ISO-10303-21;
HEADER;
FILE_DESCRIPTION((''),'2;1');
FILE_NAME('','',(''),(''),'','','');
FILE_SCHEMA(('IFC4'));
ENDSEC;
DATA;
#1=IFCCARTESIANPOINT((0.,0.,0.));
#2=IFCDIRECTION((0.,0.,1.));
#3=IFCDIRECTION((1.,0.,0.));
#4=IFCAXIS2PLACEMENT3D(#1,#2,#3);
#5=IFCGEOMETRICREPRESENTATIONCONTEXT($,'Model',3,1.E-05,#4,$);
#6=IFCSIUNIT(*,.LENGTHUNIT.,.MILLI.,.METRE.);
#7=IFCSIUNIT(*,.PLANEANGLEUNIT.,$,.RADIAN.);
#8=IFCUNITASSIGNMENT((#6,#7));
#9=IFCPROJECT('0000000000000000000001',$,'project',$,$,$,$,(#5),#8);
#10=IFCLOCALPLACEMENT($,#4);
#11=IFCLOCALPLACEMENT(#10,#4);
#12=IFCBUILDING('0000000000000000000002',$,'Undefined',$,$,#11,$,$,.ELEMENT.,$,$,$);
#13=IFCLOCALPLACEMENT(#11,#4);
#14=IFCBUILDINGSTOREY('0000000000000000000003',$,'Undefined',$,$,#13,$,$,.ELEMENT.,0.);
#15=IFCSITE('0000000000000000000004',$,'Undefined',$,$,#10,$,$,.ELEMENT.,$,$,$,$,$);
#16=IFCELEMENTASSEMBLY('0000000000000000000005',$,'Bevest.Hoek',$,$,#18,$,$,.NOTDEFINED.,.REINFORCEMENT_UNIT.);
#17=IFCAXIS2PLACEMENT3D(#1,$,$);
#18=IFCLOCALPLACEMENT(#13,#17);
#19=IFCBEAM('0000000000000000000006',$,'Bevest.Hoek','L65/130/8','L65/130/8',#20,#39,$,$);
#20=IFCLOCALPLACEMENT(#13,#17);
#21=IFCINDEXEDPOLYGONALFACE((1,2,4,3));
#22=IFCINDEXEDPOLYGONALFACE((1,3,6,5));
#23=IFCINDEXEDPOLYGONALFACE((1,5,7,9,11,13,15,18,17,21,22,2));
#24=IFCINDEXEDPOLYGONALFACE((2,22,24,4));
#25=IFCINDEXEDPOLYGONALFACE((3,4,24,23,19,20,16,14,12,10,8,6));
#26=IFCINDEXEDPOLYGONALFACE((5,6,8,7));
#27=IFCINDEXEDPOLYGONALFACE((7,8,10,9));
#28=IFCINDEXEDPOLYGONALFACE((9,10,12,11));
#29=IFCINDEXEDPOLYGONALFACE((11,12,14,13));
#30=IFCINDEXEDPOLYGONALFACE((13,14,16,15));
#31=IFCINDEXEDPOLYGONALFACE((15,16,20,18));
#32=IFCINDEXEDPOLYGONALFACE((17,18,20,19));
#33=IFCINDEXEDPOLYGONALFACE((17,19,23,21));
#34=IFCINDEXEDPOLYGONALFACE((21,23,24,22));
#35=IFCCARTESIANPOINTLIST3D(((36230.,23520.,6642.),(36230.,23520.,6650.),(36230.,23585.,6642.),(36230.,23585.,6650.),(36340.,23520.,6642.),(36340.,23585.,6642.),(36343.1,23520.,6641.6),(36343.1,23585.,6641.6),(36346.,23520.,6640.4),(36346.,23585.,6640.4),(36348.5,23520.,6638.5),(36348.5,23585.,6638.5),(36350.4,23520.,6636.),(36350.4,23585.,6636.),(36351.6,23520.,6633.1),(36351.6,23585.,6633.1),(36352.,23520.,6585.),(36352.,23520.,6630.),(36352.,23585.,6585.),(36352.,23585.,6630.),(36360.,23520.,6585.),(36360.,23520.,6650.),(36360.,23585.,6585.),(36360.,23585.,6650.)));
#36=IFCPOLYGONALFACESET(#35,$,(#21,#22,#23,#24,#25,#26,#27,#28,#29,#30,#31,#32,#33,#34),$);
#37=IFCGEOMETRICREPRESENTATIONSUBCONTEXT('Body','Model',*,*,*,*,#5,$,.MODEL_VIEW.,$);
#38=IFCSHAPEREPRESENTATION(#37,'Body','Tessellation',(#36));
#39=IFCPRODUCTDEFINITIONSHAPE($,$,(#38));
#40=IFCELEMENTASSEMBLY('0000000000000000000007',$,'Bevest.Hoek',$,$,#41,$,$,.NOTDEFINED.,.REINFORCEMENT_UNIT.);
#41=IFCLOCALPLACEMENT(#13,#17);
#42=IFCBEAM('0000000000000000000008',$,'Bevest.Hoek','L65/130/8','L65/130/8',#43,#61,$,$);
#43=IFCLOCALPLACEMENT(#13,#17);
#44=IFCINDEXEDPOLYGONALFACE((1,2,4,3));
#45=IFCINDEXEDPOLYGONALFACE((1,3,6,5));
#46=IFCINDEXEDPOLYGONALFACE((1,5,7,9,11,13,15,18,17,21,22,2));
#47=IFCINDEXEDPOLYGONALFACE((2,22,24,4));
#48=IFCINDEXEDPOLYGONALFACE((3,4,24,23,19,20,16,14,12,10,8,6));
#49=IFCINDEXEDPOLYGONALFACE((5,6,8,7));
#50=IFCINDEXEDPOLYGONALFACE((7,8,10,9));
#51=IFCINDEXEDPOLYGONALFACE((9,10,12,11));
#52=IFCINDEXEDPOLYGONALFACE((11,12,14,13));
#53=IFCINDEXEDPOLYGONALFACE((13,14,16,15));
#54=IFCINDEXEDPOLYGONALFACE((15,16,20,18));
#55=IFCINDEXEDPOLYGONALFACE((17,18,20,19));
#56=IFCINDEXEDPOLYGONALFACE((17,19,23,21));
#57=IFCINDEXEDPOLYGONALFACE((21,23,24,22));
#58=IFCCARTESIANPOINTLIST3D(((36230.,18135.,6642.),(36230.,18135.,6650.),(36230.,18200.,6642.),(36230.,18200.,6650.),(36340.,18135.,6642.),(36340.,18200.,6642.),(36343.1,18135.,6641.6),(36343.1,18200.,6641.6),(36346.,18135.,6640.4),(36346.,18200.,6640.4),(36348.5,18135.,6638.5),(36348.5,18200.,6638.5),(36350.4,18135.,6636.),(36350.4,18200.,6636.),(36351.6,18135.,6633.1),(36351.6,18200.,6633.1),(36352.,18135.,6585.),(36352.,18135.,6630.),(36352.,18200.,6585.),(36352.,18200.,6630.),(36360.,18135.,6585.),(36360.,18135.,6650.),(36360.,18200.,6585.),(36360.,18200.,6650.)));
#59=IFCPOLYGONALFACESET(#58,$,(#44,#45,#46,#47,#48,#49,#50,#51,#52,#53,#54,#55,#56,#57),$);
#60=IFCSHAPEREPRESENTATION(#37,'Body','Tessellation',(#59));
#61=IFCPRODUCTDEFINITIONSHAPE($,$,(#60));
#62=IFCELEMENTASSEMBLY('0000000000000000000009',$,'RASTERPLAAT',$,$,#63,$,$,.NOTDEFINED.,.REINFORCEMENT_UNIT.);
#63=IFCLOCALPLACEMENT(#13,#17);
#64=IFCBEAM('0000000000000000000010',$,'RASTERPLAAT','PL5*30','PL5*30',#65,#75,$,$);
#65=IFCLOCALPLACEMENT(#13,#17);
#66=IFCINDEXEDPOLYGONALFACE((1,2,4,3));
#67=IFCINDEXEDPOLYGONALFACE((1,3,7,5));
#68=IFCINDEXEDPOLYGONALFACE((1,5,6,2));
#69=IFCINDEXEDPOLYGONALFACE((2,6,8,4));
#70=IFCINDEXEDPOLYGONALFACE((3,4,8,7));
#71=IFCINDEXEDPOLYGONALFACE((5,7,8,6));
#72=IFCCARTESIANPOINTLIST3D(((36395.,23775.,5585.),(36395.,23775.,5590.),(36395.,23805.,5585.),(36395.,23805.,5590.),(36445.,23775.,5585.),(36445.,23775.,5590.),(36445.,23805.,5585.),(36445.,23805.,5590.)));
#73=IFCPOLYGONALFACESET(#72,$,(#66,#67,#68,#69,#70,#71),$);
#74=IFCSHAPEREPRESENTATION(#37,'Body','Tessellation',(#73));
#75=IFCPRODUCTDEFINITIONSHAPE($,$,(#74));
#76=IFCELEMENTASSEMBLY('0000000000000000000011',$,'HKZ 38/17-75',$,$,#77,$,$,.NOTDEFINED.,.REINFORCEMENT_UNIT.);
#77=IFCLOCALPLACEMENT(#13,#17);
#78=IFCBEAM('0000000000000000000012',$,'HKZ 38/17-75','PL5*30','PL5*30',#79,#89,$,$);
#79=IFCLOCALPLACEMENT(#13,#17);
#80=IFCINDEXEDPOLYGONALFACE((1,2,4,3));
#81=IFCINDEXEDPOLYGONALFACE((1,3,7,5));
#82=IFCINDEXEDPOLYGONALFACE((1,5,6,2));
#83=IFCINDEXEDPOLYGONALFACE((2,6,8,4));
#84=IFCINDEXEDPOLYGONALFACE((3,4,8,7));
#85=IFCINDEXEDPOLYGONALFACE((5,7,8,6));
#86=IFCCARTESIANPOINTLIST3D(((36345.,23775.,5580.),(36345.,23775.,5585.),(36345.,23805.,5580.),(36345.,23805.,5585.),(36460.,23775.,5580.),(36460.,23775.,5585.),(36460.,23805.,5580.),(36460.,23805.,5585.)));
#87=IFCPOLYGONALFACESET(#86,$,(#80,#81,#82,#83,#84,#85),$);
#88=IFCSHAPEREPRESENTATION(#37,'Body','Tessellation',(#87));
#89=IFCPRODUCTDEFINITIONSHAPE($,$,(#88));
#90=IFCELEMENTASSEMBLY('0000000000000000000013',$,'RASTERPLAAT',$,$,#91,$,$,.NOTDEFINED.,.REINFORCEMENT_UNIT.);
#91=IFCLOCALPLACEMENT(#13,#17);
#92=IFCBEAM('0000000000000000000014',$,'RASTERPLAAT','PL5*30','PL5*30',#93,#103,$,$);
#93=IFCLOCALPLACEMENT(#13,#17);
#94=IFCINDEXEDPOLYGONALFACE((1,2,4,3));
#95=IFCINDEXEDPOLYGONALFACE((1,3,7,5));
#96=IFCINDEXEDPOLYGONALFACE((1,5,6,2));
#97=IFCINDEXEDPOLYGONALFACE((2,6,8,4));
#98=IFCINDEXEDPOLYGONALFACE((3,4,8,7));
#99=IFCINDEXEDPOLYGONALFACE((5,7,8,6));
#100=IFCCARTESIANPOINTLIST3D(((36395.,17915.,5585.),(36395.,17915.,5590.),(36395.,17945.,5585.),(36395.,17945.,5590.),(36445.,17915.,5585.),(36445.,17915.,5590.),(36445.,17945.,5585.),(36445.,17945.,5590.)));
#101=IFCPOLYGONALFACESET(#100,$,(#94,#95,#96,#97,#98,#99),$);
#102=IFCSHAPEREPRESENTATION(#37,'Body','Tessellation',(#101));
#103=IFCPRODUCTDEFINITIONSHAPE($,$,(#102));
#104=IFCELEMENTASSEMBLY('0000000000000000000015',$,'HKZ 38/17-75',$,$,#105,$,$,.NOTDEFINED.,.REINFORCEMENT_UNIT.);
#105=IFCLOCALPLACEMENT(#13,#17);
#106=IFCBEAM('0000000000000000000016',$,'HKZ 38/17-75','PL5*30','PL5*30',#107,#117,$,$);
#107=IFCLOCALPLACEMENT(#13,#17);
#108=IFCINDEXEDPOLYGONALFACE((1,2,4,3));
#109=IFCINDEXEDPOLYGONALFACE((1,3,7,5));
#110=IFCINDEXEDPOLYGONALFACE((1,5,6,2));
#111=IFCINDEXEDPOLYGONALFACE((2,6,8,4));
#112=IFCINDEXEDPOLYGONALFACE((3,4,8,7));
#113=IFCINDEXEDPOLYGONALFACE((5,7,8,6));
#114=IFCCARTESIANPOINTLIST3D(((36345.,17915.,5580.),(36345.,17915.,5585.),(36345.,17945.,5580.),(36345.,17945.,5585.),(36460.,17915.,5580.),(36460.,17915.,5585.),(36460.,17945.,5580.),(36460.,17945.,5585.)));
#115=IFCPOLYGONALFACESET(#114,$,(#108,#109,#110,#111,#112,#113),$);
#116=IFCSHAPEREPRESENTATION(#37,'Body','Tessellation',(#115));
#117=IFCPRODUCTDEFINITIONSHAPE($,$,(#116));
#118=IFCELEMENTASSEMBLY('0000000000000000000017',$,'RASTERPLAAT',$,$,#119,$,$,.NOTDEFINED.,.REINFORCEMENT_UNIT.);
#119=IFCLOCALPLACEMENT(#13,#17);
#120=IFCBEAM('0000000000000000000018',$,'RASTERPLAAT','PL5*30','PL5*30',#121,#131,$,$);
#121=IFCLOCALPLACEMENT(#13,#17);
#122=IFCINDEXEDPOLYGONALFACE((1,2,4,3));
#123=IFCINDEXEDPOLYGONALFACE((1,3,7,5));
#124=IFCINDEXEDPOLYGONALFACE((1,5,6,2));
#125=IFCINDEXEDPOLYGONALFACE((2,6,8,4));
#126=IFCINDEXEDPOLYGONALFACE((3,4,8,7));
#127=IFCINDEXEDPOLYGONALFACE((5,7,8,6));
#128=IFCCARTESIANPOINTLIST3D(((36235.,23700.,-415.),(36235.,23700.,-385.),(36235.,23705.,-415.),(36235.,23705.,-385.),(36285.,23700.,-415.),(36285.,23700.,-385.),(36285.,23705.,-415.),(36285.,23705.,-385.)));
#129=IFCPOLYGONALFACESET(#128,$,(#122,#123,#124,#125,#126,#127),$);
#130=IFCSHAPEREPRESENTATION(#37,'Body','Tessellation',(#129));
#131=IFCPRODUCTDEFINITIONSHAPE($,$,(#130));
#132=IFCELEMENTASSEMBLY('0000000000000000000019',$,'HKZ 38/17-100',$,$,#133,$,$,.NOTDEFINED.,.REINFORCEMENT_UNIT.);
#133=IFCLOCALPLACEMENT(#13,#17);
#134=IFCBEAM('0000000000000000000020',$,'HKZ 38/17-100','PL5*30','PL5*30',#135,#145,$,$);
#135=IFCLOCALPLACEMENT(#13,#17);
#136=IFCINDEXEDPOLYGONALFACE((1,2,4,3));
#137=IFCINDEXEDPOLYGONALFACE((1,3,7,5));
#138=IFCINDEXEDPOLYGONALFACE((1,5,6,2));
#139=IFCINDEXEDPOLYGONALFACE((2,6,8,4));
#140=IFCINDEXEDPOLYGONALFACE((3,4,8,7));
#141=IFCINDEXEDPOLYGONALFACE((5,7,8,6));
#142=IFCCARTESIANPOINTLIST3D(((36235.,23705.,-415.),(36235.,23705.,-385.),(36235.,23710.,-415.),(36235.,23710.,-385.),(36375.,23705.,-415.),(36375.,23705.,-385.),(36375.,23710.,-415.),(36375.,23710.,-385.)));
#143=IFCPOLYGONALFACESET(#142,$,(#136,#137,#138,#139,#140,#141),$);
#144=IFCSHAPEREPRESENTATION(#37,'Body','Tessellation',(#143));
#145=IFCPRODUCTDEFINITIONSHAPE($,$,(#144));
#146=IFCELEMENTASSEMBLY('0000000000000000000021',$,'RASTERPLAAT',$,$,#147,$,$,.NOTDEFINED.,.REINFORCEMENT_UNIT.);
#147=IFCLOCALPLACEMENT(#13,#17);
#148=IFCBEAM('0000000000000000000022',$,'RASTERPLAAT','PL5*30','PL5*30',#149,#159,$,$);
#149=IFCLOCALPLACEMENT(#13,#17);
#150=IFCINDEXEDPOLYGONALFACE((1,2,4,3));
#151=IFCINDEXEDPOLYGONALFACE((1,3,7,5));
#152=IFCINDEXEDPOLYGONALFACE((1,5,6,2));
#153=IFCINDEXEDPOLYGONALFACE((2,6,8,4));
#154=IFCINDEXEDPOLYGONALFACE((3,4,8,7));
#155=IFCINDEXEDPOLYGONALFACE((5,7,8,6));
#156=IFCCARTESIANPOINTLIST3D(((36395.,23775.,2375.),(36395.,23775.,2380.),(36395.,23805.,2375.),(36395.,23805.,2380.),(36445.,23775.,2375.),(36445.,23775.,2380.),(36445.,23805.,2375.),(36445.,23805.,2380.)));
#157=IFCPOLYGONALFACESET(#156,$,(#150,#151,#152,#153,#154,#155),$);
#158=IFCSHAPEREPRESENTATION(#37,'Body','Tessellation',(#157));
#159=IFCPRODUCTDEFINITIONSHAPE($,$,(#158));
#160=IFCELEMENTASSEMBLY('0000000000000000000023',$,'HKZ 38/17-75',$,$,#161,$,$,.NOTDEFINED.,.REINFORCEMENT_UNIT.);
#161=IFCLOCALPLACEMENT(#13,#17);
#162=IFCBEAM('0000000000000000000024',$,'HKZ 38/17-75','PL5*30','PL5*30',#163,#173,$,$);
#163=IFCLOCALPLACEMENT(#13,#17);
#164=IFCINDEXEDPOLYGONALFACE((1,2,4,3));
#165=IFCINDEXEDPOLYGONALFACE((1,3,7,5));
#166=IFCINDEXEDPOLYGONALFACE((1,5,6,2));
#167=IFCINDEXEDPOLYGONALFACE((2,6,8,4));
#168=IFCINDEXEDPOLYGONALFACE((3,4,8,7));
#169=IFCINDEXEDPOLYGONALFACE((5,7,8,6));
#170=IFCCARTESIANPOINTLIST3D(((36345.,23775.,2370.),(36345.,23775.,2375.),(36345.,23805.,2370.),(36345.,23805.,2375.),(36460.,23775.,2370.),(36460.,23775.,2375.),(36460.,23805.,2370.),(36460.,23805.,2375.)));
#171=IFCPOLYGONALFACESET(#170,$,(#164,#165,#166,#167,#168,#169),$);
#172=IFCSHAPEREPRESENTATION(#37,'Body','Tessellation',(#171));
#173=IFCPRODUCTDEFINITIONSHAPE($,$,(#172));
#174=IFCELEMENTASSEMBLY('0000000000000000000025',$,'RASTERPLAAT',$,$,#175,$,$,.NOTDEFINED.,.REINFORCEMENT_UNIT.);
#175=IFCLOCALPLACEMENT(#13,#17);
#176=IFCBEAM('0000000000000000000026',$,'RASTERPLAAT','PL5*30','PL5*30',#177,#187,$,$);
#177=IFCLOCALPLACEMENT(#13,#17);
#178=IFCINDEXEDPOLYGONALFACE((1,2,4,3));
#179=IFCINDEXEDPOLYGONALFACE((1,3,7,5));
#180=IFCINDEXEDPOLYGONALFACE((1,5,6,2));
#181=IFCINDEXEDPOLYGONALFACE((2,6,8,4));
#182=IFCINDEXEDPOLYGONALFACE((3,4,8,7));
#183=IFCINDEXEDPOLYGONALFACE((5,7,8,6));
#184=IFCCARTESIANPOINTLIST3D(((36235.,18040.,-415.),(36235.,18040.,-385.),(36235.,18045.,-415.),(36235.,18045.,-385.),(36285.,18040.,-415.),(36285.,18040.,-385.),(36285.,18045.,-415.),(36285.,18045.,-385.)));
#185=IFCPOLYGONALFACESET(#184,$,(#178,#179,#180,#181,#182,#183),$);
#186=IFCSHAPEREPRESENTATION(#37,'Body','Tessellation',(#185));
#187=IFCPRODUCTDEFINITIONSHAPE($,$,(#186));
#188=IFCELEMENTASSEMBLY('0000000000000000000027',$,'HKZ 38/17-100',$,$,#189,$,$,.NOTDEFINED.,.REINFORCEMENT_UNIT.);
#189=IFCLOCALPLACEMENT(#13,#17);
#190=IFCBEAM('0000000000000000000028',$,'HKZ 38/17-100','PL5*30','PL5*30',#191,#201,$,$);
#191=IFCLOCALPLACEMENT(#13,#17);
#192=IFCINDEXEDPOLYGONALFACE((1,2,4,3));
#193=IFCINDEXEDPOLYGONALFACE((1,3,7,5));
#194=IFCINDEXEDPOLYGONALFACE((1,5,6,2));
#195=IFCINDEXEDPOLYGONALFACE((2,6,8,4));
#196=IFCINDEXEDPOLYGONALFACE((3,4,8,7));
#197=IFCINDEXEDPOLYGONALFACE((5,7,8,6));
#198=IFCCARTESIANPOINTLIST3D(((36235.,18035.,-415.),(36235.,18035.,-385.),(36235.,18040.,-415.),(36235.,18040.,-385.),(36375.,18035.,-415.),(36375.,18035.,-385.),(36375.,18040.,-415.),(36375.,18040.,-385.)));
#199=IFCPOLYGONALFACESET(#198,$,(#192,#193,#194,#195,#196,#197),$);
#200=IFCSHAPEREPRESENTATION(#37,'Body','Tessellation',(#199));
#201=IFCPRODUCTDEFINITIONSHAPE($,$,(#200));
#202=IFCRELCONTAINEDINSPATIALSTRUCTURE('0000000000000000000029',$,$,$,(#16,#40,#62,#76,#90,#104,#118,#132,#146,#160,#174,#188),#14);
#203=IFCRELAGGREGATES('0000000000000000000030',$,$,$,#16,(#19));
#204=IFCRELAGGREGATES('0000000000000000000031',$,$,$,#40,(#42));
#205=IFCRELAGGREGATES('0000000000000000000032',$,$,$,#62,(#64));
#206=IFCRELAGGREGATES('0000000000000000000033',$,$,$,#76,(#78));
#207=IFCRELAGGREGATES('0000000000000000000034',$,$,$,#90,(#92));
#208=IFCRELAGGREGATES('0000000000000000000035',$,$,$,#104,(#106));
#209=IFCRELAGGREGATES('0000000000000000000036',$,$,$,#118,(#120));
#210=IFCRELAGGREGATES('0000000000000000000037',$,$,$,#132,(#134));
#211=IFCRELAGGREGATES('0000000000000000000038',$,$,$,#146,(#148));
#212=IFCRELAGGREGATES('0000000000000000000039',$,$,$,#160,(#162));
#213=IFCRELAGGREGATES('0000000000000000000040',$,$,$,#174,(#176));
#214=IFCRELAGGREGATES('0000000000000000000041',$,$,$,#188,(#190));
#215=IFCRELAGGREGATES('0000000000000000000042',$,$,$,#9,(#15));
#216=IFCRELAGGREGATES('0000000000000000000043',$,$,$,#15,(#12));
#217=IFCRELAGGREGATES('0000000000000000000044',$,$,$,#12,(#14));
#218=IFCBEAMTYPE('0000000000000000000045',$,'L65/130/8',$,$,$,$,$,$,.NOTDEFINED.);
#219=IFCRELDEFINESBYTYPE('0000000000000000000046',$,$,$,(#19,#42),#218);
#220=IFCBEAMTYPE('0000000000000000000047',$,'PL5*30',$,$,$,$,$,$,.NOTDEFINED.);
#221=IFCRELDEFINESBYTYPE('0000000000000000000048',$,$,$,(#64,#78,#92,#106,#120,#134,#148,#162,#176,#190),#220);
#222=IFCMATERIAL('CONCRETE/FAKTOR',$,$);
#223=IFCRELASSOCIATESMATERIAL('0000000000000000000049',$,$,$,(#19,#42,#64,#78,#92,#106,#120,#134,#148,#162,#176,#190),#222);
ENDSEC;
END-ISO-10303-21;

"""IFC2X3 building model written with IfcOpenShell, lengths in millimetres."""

from ifc_helpers import new_model, si_unit, frame, frame_2d, origin_with_axes, place, context, subcontext, project, spatial, rectangle, l_section, extrude, material, type_object, element, aggregate, save


model = new_model("IFC2X3")

# Units and contexts
model_context = context("Model", 3, precision=1e-05, world=origin_with_axes())
body_context = subcontext(model_context, "Body", "Model", "MODEL_VIEW")
ifc_project = project(units=[si_unit("LENGTHUNIT", "METRE", prefix="MILLI"), si_unit("PLANEANGLEUNIT", "RADIAN")], contexts=[model_context])

# Site, building, storey
site_placement = place(None, origin_with_axes())
site = spatial("IfcSite", under=ifc_project, at=site_placement, Name="Undefined", CompositionType="ELEMENT")
building_placement = place(site_placement, origin_with_axes())
building = spatial("IfcBuilding", under=site, at=building_placement, Name="Undefined", CompositionType="ELEMENT")
storey_placement = place(building_placement, origin_with_axes())
storey = spatial("IfcBuildingStorey", under=building, at=storey_placement, Name="Undefined", CompositionType="ELEMENT", Elevation=0.0)

# Element assemblies, beams
assembly_1_placement = place(storey_placement, origin_with_axes())
assembly_1 = element("IfcElementAssembly", 1, at=assembly_1_placement, inside=storey, Name="Bevest.Hoek", AssemblyPlace="NOTDEFINED", PredefinedType="REINFORCEMENT_UNIT")
ifc_material_1 = material(Name="CONCRETE/FAKTOR")
beam_type_1 = type_object("IfcBeamType", Name="L65/130/8", PredefinedType="NOTDEFINED")
beam_1_placement = place(assembly_1_placement, frame((36295.0, 23520.0, 6617.5), z_axis=(0.0, 0.0, -1.0), x_axis=(0.0, 1.0, 0.0)))
beam_1 = element("IfcBeam", 2, at=beam_1_placement, type_object=beam_type_1, material=ifc_material_1, Name="Bevest.Hoek", Description="L65/130/8", ObjectType="L65/130/8", context=body_context, shape_type="SweptSolid", body=[
    extrude(l_section(Depth=65.0, Width=130.0, Thickness=8.0, FilletRadius=12.0, at=frame_2d((0.0, 0.0), x_axis=(1.0, 0.0))), frame((65.0, 0.0, 0.0), z_axis=(-1.0, 0.0, 0.0), x_axis=(0.0, -1.0, 0.0)), (0.0, 0.0, 1.0), 65.0),
])
aggregate(assembly_1, [beam_1])
assembly_2_placement = place(storey_placement, origin_with_axes())
assembly_2 = element("IfcElementAssembly", 3, at=assembly_2_placement, inside=storey, Name="Bevest.Hoek", AssemblyPlace="NOTDEFINED", PredefinedType="REINFORCEMENT_UNIT")
beam_2_placement = place(assembly_2_placement, frame((36295.0, 18135.0, 6617.5), z_axis=(0.0, 0.0, -1.0), x_axis=(0.0, 1.0, 0.0)))
beam_2 = element("IfcBeam", 4, at=beam_2_placement, type_object=beam_type_1, material=ifc_material_1, Name="Bevest.Hoek", Description="L65/130/8", ObjectType="L65/130/8", context=body_context, shape_type="SweptSolid", body=[
    extrude(l_section(Depth=65.0, Width=130.0, Thickness=8.0, FilletRadius=12.0, at=frame_2d((0.0, 0.0), x_axis=(1.0, 0.0))), frame((65.0, 0.0, 0.0), z_axis=(-1.0, 0.0, 0.0), x_axis=(0.0, -1.0, 0.0)), (0.0, 0.0, 1.0), 65.0),
])
aggregate(assembly_2, [beam_2])
assembly_3_placement = place(storey_placement, origin_with_axes())
assembly_3 = element("IfcElementAssembly", 5, at=assembly_3_placement, inside=storey, Name="RASTERPLAAT", AssemblyPlace="NOTDEFINED", PredefinedType="REINFORCEMENT_UNIT")
beam_type_2 = type_object("IfcBeamType", Name="PL5*30", PredefinedType="NOTDEFINED")
beam_3_placement = place(assembly_3_placement, frame((36395.0, 23790.0, 5587.5), z_axis=(0.0, 1.0, 0.0), x_axis=(1.0, 0.0, 0.0)))
beam_3 = element("IfcBeam", 6, at=beam_3_placement, type_object=beam_type_2, material=ifc_material_1, Name="RASTERPLAAT", Description="PL5*30", ObjectType="PL5*30", context=body_context, shape_type="SweptSolid", body=[
    extrude(rectangle(XDim=5.0, YDim=30.0, at=frame_2d((0.0, 0.0), x_axis=(1.0, 0.0))), frame((50.0, 0.0, 0.0), z_axis=(-1.0, 0.0, 0.0), x_axis=(0.0, -1.0, 0.0)), (0.0, 0.0, 1.0), 50.0),
])
aggregate(assembly_3, [beam_3])
assembly_4_placement = place(storey_placement, origin_with_axes())
assembly_4 = element("IfcElementAssembly", 7, at=assembly_4_placement, inside=storey, Name="HKZ 38/17-75", AssemblyPlace="NOTDEFINED", PredefinedType="REINFORCEMENT_UNIT")
beam_4_placement = place(assembly_4_placement, frame((36345.0, 23790.0, 5582.5), z_axis=(0.0, 1.0, 0.0), x_axis=(1.0, 0.0, 0.0)))
beam_4 = element("IfcBeam", 8, at=beam_4_placement, type_object=beam_type_2, material=ifc_material_1, Name="HKZ 38/17-75", Description="PL5*30", ObjectType="PL5*30", context=body_context, shape_type="SweptSolid", body=[
    extrude(rectangle(XDim=5.0, YDim=30.0, at=frame_2d((0.0, 0.0), x_axis=(1.0, 0.0))), frame((115.0, 0.0, 0.0), z_axis=(-1.0, 0.0, 0.0), x_axis=(0.0, -1.0, 0.0)), (0.0, 0.0, 1.0), 115.0),
])
aggregate(assembly_4, [beam_4])
assembly_5_placement = place(storey_placement, origin_with_axes())
assembly_5 = element("IfcElementAssembly", 9, at=assembly_5_placement, inside=storey, Name="RASTERPLAAT", AssemblyPlace="NOTDEFINED", PredefinedType="REINFORCEMENT_UNIT")
beam_5_placement = place(assembly_5_placement, frame((36395.0, 17930.0, 5587.5), z_axis=(0.0, -1.0, 0.0), x_axis=(1.0, 0.0, 0.0)))
beam_5 = element("IfcBeam", 10, at=beam_5_placement, type_object=beam_type_2, material=ifc_material_1, Name="RASTERPLAAT", Description="PL5*30", ObjectType="PL5*30", context=body_context, shape_type="SweptSolid", body=[
    extrude(rectangle(XDim=5.0, YDim=30.0, at=frame_2d((0.0, 0.0), x_axis=(1.0, 0.0))), frame((50.0, 0.0, 0.0), z_axis=(-1.0, 0.0, 0.0), x_axis=(0.0, -1.0, 0.0)), (0.0, 0.0, 1.0), 50.0),
])
aggregate(assembly_5, [beam_5])
assembly_6_placement = place(storey_placement, origin_with_axes())
assembly_6 = element("IfcElementAssembly", 11, at=assembly_6_placement, inside=storey, Name="HKZ 38/17-75", AssemblyPlace="NOTDEFINED", PredefinedType="REINFORCEMENT_UNIT")
beam_6_placement = place(assembly_6_placement, frame((36345.0, 17930.0, 5582.5), z_axis=(0.0, -1.0, 0.0), x_axis=(1.0, 0.0, 0.0)))
beam_6 = element("IfcBeam", 12, at=beam_6_placement, type_object=beam_type_2, material=ifc_material_1, Name="HKZ 38/17-75", Description="PL5*30", ObjectType="PL5*30", context=body_context, shape_type="SweptSolid", body=[
    extrude(rectangle(XDim=5.0, YDim=30.0, at=frame_2d((0.0, 0.0), x_axis=(1.0, 0.0))), frame((115.0, 0.0, 0.0), z_axis=(-1.0, 0.0, 0.0), x_axis=(0.0, -1.0, 0.0)), (0.0, 0.0, 1.0), 115.0),
])
aggregate(assembly_6, [beam_6])
assembly_7_placement = place(storey_placement, origin_with_axes())
assembly_7 = element("IfcElementAssembly", 13, at=assembly_7_placement, inside=storey, Name="RASTERPLAAT", AssemblyPlace="NOTDEFINED", PredefinedType="REINFORCEMENT_UNIT")
beam_7_placement = place(assembly_7_placement, frame((36235.0, 23702.5, -400.0), z_axis=(0.0, 0.0, -1.0), x_axis=(1.0, 0.0, 0.0)))
beam_7 = element("IfcBeam", 14, at=beam_7_placement, type_object=beam_type_2, material=ifc_material_1, Name="RASTERPLAAT", Description="PL5*30", ObjectType="PL5*30", context=body_context, shape_type="SweptSolid", body=[
    extrude(rectangle(XDim=5.0, YDim=30.0, at=frame_2d((0.0, 0.0), x_axis=(1.0, 0.0))), frame((50.0, 0.0, 0.0), z_axis=(-1.0, 0.0, 0.0), x_axis=(0.0, -1.0, 0.0)), (0.0, 0.0, 1.0), 50.0),
])
aggregate(assembly_7, [beam_7])
assembly_8_placement = place(storey_placement, origin_with_axes())
assembly_8 = element("IfcElementAssembly", 15, at=assembly_8_placement, inside=storey, Name="HKZ 38/17-100", AssemblyPlace="NOTDEFINED", PredefinedType="REINFORCEMENT_UNIT")
beam_8_placement = place(assembly_8_placement, frame((36375.0, 23707.5, -400.0), z_axis=(0.0, 0.0, -1.0), x_axis=(-1.0, 0.0, 0.0)))
beam_8 = element("IfcBeam", 16, at=beam_8_placement, type_object=beam_type_2, material=ifc_material_1, Name="HKZ 38/17-100", Description="PL5*30", ObjectType="PL5*30", context=body_context, shape_type="SweptSolid", body=[
    extrude(rectangle(XDim=5.0, YDim=30.0, at=frame_2d((0.0, 0.0), x_axis=(1.0, 0.0))), frame((140.0, 0.0, 0.0), z_axis=(-1.0, 0.0, 0.0), x_axis=(0.0, -1.0, 0.0)), (0.0, 0.0, 1.0), 140.0),
])
aggregate(assembly_8, [beam_8])
assembly_9_placement = place(storey_placement, origin_with_axes())
assembly_9 = element("IfcElementAssembly", 17, at=assembly_9_placement, inside=storey, Name="RASTERPLAAT", AssemblyPlace="NOTDEFINED", PredefinedType="REINFORCEMENT_UNIT")
beam_9_placement = place(assembly_9_placement, frame((36395.0, 23790.0, 2377.5), z_axis=(0.0, 1.0, 0.0), x_axis=(1.0, 0.0, 0.0)))
beam_9 = element("IfcBeam", 18, at=beam_9_placement, type_object=beam_type_2, material=ifc_material_1, Name="RASTERPLAAT", Description="PL5*30", ObjectType="PL5*30", context=body_context, shape_type="SweptSolid", body=[
    extrude(rectangle(XDim=5.0, YDim=30.0, at=frame_2d((0.0, 0.0), x_axis=(1.0, 0.0))), frame((50.0, 0.0, 0.0), z_axis=(-1.0, 0.0, 0.0), x_axis=(0.0, -1.0, 0.0)), (0.0, 0.0, 1.0), 50.0),
])
aggregate(assembly_9, [beam_9])
assembly_10_placement = place(storey_placement, origin_with_axes())
assembly_10 = element("IfcElementAssembly", 19, at=assembly_10_placement, inside=storey, Name="HKZ 38/17-75", AssemblyPlace="NOTDEFINED", PredefinedType="REINFORCEMENT_UNIT")
beam_10_placement = place(assembly_10_placement, frame((36345.0, 23790.0, 2372.5), z_axis=(0.0, 1.0, 0.0), x_axis=(1.0, 0.0, 0.0)))
beam_10 = element("IfcBeam", 20, at=beam_10_placement, type_object=beam_type_2, material=ifc_material_1, Name="HKZ 38/17-75", Description="PL5*30", ObjectType="PL5*30", context=body_context, shape_type="SweptSolid", body=[
    extrude(rectangle(XDim=5.0, YDim=30.0, at=frame_2d((0.0, 0.0), x_axis=(1.0, 0.0))), frame((115.0, 0.0, 0.0), z_axis=(-1.0, 0.0, 0.0), x_axis=(0.0, -1.0, 0.0)), (0.0, 0.0, 1.0), 115.0),
])
aggregate(assembly_10, [beam_10])
assembly_11_placement = place(storey_placement, origin_with_axes())
assembly_11 = element("IfcElementAssembly", 21, at=assembly_11_placement, inside=storey, Name="RASTERPLAAT", AssemblyPlace="NOTDEFINED", PredefinedType="REINFORCEMENT_UNIT")
beam_11_placement = place(assembly_11_placement, frame((36235.0, 18042.5, -400.0), z_axis=(0.0, 0.0, 1.0), x_axis=(1.0, 0.0, 0.0)))
beam_11 = element("IfcBeam", 22, at=beam_11_placement, type_object=beam_type_2, material=ifc_material_1, Name="RASTERPLAAT", Description="PL5*30", ObjectType="PL5*30", context=body_context, shape_type="SweptSolid", body=[
    extrude(rectangle(XDim=5.0, YDim=30.0, at=frame_2d((0.0, 0.0), x_axis=(1.0, 0.0))), frame((50.0, 0.0, 0.0), z_axis=(-1.0, 0.0, 0.0), x_axis=(0.0, -1.0, 0.0)), (0.0, 0.0, 1.0), 50.0),
])
aggregate(assembly_11, [beam_11])
assembly_12_placement = place(storey_placement, origin_with_axes())
assembly_12 = element("IfcElementAssembly", 23, at=assembly_12_placement, inside=storey, Name="HKZ 38/17-100", AssemblyPlace="NOTDEFINED", PredefinedType="REINFORCEMENT_UNIT")
beam_12_placement = place(assembly_12_placement, frame((36375.0, 18037.5, -400.0), z_axis=(0.0, 0.0, 1.0), x_axis=(-1.0, 0.0, 0.0)))
beam_12 = element("IfcBeam", 24, at=beam_12_placement, type_object=beam_type_2, material=ifc_material_1, Name="HKZ 38/17-100", Description="PL5*30", ObjectType="PL5*30", context=body_context, shape_type="SweptSolid", body=[
    extrude(rectangle(XDim=5.0, YDim=30.0, at=frame_2d((0.0, 0.0), x_axis=(1.0, 0.0))), frame((140.0, 0.0, 0.0), z_axis=(-1.0, 0.0, 0.0), x_axis=(0.0, -1.0, 0.0)), (0.0, 0.0, 1.0), 140.0),
])
aggregate(assembly_12, [beam_12])

save(model, "model.ifc")
